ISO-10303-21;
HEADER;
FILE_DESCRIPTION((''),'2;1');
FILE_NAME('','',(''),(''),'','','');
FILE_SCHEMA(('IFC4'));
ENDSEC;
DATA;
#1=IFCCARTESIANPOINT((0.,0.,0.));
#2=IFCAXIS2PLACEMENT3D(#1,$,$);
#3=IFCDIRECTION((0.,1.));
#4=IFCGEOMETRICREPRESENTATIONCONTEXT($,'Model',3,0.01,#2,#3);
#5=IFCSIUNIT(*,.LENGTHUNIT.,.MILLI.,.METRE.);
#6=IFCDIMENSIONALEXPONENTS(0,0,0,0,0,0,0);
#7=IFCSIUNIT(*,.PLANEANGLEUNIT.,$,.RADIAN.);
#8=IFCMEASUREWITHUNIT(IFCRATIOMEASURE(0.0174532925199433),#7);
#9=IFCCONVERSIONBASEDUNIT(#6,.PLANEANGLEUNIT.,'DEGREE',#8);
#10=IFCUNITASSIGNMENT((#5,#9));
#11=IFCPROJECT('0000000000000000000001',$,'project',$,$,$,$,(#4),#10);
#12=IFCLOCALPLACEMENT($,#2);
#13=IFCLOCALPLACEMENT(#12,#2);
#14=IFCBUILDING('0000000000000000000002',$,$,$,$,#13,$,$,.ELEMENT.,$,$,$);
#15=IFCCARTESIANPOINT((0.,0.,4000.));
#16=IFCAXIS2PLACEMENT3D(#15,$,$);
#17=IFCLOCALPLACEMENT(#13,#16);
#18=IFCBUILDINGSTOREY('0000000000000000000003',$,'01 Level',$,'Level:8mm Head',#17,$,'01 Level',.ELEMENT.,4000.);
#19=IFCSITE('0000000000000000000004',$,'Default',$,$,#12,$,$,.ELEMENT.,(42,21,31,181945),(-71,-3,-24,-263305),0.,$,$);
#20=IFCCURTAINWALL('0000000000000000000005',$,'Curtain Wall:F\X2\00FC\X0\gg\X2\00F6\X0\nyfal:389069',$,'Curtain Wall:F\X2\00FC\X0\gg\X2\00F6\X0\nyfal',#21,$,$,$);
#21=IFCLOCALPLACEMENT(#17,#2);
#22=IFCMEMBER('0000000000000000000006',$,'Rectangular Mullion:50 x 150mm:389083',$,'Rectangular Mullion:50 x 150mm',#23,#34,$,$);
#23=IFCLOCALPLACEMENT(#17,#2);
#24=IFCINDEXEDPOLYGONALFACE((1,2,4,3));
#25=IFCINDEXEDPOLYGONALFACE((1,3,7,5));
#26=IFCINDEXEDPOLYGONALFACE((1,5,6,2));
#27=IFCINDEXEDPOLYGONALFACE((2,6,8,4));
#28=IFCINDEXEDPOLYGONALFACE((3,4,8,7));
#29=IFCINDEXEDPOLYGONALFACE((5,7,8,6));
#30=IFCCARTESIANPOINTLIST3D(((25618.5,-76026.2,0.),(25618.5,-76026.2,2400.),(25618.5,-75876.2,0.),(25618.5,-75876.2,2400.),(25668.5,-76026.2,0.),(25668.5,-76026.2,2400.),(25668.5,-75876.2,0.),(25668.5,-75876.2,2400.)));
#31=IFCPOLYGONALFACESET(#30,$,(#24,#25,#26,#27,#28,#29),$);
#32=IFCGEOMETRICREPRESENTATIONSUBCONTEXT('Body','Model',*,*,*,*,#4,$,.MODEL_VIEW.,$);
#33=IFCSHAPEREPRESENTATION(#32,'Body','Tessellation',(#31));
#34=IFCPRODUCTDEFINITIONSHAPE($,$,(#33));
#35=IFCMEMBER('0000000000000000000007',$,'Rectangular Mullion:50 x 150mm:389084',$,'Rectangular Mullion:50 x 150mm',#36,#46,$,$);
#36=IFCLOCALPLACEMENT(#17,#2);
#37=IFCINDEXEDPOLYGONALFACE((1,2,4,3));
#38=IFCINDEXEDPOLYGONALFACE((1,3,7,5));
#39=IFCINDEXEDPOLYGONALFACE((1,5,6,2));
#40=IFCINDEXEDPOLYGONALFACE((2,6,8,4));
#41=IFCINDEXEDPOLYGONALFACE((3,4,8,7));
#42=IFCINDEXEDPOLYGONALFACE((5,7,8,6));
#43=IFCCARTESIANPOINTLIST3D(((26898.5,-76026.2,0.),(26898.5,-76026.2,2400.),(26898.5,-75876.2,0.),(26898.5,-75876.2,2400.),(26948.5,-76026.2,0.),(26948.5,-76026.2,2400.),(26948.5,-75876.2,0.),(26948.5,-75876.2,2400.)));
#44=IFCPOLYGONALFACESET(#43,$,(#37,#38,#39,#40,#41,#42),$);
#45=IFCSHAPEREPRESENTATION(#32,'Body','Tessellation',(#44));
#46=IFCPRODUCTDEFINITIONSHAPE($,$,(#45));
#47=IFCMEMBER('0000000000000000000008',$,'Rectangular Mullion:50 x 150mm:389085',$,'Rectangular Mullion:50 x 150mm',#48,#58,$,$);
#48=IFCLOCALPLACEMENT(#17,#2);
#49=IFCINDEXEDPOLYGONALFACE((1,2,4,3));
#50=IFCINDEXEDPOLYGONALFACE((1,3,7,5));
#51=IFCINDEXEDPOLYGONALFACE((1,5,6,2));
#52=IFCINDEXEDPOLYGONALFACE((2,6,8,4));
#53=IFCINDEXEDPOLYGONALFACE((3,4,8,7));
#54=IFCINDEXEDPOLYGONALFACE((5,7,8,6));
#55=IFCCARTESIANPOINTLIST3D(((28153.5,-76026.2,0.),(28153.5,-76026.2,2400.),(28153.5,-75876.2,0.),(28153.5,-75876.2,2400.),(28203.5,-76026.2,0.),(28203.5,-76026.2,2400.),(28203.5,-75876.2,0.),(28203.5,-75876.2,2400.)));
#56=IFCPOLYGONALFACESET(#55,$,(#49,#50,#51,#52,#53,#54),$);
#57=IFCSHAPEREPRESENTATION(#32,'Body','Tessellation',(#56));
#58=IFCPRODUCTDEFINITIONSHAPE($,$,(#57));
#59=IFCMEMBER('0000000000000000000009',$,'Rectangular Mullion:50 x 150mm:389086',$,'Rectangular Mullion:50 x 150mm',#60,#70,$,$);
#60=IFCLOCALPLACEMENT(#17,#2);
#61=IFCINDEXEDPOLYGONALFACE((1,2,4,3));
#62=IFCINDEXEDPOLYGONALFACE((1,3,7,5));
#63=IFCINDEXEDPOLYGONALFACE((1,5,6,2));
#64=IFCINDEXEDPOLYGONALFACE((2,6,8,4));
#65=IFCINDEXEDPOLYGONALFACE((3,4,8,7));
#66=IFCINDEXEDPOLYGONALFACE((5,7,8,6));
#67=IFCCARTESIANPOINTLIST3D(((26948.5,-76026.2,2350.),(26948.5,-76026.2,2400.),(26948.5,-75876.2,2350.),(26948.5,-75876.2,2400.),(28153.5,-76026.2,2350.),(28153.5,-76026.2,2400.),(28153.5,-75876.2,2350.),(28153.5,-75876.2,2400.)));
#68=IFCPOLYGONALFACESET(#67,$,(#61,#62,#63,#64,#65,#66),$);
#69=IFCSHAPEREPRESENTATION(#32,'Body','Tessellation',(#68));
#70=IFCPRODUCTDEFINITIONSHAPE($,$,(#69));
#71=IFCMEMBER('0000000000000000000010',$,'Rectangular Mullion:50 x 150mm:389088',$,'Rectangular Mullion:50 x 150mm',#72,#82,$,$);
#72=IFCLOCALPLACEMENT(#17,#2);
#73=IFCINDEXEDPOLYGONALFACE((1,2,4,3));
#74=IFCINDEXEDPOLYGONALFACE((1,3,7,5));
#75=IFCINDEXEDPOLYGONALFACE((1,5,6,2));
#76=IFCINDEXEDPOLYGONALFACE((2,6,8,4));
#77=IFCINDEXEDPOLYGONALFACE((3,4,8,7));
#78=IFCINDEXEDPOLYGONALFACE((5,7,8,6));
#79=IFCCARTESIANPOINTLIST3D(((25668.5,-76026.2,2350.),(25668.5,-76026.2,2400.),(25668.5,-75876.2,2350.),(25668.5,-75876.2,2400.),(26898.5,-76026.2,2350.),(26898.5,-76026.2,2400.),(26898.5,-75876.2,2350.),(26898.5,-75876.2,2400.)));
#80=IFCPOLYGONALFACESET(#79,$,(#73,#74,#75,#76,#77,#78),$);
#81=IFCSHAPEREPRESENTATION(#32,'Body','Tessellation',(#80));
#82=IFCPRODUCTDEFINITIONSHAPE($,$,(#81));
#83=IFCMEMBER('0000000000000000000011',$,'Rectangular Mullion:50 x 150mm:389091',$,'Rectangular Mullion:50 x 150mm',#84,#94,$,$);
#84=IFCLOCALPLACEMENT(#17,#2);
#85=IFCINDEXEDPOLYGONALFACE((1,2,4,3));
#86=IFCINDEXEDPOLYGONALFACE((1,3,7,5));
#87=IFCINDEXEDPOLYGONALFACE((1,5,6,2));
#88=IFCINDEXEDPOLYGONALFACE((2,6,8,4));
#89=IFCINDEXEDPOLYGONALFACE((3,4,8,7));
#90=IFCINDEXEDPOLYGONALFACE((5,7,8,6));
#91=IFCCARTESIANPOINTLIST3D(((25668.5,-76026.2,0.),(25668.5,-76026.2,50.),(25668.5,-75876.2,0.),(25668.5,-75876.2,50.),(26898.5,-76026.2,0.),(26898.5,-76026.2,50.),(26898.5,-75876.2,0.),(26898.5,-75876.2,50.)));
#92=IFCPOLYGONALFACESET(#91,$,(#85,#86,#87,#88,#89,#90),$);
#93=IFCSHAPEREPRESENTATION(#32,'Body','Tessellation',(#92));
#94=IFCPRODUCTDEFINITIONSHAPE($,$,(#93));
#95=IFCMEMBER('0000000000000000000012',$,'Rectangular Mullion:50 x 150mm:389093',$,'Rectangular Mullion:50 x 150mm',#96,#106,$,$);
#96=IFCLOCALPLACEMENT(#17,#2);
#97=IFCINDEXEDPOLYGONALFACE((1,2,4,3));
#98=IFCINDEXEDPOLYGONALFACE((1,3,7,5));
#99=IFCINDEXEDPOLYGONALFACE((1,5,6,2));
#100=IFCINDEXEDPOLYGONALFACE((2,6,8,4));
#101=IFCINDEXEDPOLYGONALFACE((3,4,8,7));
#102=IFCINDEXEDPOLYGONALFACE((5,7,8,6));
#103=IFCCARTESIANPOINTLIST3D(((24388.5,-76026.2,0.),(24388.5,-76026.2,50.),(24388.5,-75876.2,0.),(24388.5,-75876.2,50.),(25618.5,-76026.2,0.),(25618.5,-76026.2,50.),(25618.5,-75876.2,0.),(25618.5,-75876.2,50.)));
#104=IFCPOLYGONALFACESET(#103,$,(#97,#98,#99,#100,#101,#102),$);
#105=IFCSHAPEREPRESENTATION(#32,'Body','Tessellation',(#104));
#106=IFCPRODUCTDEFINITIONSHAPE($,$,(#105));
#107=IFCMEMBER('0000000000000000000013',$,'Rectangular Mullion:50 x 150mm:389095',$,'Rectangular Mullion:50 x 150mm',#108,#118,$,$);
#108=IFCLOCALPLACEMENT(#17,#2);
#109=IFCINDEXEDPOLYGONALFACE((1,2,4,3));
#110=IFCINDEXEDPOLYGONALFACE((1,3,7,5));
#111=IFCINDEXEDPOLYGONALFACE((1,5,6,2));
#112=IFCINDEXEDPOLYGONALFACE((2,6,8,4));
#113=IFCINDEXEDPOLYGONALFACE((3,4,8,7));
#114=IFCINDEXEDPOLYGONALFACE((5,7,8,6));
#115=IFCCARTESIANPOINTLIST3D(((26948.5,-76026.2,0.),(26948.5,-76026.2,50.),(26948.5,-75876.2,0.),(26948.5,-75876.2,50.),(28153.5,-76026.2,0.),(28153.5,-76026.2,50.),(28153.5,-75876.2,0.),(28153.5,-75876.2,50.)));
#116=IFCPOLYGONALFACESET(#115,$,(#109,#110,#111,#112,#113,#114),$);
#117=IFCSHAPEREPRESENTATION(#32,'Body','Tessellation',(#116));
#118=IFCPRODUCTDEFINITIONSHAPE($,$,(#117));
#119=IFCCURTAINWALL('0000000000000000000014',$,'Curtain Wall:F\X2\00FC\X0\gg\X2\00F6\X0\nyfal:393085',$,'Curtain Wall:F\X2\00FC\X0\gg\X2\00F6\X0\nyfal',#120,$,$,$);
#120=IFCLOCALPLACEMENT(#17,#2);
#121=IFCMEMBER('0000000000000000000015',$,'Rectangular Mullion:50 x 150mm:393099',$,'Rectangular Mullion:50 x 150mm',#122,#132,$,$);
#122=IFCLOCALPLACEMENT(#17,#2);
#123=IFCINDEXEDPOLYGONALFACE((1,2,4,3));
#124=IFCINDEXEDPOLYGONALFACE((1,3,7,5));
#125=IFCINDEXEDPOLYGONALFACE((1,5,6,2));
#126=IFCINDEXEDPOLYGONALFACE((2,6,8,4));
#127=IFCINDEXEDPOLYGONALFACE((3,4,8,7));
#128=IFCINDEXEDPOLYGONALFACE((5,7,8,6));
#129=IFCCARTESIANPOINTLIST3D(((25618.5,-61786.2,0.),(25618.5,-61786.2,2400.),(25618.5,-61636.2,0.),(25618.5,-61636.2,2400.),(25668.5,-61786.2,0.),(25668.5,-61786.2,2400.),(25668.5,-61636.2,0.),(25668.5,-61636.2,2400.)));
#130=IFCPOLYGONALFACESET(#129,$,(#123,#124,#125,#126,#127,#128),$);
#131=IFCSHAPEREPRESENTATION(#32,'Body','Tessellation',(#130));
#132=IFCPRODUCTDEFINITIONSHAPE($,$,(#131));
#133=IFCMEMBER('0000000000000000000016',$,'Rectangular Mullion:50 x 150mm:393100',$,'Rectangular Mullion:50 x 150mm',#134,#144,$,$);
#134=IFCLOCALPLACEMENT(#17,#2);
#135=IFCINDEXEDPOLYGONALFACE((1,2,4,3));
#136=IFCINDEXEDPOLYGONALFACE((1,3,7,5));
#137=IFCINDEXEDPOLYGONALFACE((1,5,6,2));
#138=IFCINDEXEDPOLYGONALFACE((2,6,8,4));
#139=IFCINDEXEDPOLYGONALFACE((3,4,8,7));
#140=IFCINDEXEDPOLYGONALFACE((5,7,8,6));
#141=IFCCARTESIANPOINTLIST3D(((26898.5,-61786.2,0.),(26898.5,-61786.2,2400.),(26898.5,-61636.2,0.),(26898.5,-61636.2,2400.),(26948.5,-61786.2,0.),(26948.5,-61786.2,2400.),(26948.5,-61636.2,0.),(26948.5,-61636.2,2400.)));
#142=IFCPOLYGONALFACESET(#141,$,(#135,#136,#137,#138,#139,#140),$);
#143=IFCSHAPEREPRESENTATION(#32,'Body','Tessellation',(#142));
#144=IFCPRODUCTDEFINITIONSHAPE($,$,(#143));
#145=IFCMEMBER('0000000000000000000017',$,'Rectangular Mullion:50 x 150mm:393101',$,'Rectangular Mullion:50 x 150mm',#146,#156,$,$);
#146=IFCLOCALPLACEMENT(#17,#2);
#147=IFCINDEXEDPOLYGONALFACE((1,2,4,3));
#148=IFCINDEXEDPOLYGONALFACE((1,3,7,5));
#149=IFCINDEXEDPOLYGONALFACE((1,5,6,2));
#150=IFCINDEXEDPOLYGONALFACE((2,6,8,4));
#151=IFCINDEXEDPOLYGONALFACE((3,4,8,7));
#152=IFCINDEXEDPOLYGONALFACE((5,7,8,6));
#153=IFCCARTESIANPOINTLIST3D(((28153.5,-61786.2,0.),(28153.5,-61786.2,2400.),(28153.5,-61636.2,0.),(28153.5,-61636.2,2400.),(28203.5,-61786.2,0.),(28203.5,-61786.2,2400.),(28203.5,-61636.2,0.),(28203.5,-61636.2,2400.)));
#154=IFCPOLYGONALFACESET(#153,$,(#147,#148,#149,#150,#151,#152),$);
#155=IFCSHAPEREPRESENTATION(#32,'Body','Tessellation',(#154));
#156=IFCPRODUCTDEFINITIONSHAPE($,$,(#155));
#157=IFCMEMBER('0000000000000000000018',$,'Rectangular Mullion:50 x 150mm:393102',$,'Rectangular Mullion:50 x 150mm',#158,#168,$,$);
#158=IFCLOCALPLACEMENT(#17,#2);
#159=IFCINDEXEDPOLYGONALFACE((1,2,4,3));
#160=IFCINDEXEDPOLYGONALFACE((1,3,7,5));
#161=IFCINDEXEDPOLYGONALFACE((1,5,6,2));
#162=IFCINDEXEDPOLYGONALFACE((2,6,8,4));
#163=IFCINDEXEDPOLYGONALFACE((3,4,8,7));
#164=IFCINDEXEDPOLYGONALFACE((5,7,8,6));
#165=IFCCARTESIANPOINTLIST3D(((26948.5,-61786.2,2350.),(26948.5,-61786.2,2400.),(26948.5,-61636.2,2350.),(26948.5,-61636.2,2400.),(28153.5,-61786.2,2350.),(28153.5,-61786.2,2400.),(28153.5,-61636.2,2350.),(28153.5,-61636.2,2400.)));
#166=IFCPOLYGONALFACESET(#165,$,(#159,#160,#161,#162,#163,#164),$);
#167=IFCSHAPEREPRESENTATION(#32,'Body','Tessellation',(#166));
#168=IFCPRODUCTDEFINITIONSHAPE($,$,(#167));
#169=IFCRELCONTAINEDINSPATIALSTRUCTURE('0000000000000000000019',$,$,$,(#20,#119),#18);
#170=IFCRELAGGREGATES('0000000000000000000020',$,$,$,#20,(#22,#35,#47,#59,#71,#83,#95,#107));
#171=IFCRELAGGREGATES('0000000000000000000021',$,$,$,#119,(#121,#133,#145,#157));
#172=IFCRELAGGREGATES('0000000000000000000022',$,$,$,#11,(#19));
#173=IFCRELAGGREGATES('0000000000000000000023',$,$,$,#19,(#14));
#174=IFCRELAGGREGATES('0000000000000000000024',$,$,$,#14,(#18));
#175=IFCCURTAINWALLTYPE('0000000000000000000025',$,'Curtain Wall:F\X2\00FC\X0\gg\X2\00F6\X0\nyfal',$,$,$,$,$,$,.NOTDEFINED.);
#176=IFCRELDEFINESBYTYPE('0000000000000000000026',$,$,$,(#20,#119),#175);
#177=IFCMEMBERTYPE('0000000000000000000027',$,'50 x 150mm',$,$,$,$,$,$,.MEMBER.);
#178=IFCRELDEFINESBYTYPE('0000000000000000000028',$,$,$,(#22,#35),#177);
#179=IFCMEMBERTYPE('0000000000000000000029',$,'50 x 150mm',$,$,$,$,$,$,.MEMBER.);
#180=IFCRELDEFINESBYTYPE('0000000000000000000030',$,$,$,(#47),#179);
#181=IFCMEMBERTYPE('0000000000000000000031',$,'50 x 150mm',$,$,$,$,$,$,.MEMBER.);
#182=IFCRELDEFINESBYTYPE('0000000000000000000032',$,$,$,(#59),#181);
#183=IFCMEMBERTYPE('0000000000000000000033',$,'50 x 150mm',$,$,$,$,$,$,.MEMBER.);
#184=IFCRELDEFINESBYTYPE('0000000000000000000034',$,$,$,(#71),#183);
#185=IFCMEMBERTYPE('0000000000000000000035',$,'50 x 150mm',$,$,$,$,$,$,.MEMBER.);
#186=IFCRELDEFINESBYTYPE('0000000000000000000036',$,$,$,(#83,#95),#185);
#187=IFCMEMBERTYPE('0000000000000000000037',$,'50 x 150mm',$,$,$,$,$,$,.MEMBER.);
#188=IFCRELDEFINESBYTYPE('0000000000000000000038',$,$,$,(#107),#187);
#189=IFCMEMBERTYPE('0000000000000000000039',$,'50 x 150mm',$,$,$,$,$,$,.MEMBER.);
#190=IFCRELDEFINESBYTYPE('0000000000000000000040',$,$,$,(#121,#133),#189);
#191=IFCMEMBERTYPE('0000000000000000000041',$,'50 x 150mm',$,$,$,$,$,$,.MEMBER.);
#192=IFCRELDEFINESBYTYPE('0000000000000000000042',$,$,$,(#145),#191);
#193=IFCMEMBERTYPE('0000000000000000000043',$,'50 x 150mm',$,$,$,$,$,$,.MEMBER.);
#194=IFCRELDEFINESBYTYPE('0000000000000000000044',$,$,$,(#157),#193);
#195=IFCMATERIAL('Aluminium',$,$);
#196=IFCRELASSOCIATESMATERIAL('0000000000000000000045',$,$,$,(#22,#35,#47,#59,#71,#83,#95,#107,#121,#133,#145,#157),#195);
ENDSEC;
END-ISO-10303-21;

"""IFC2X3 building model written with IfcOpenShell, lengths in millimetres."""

from ifc_helpers import new_model, entity, si_unit, converted_unit, direction, frame, origin, origin_2d_with_axis, place, context, subcontext, project, spatial, rectangle, extrude, source, transform, mapped, material, type_object, type_shapes, element, aggregate, save


model = new_model("IFC2X3")

# Units and contexts
model_context = context("Model", 3, precision=0.01, world=origin(), true_north=direction((0.0, 1.0)))
body_context = subcontext(model_context, "Body", "Model", "MODEL_VIEW")
ifc_project = project(units=[si_unit("LENGTHUNIT", "METRE", prefix="MILLI"), converted_unit("PLANEANGLEUNIT", "DEGREE", entity("IfcRatioMeasure", 0.0174532925199433), si_unit("PLANEANGLEUNIT", "RADIAN"), dimensions=[0, 0, 0, 0, 0, 0, 0])], contexts=[model_context])

# Site, building, storey
site_placement = place(None, origin())
site = spatial("IfcSite", under=ifc_project, at=site_placement, Name="Default", CompositionType="ELEMENT", RefLatitude=(42, 21, 31, 181945), RefLongitude=(-71, -3, -24, -263305), RefElevation=0.0)
building_placement = place(site_placement, origin())
building = spatial("IfcBuilding", under=site, at=building_placement, CompositionType="ELEMENT")
storey_placement = place(building_placement, frame((0.0, 0.0, 4000.0)))
storey = spatial("IfcBuildingStorey", under=building, at=storey_placement, Name="01 Level", ObjectType="Level:8mm Head", LongName="01 Level", CompositionType="ELEMENT", Elevation=4000.0)

# Curtain walls, members
curtain_wall_type = type_object("IfcCurtainWallType", Name="Curtain Wall:Függönyfal", PredefinedType="NOTDEFINED")
curtain_wall_1_placement = place(storey_placement, frame((0.0, 0.0, -4000.0)))
curtain_wall_1 = element("IfcCurtainWall", 1, at=curtain_wall_1_placement, inside=storey, type_object=curtain_wall_type, Name="Curtain Wall:Függönyfal:389069", ObjectType="Curtain Wall:Függönyfal")
ifc_material_1 = material(Name="Aluminium")
member_type_1 = type_object("IfcMemberType", Name="50 x 150mm", PredefinedType="MEMBER")
shared_shape_1 = source(origin(), body_context, "Body", "SweptSolid", [
    extrude(rectangle(XDim=150.0, YDim=50.0, at=origin_2d_with_axis()), frame((0.0, 0.0, -2400.0), z_axis=(0.0, 0.0, 1.0), x_axis=(0.0, -1.0, 0.0)), (0.0, 0.0, 1.0), 2400.0),
])
type_shapes(member_type_1, [shared_shape_1])
member_1_placement = place(storey_placement, frame((25643.5, -75951.2, 0.0), z_axis=(0.0, 0.0, -1.0), x_axis=(-1.0, 0.0, 0.0)))
member_1 = element("IfcMember", 2, at=member_1_placement, type_object=member_type_1, material=ifc_material_1, Name="Rectangular Mullion:50 x 150mm:389083", ObjectType="Rectangular Mullion:50 x 150mm", context=body_context, shape_type="MappedRepresentation", body=[
    mapped(shared_shape_1, transform((0.0, 0.0, 0.0), scale=1.0)),
])
member_2_placement = place(storey_placement, frame((26923.5, -75951.2, 0.0), z_axis=(0.0, 0.0, -1.0), x_axis=(-1.0, 0.0, 0.0)))
member_2 = element("IfcMember", 3, at=member_2_placement, type_object=member_type_1, material=ifc_material_1, Name="Rectangular Mullion:50 x 150mm:389084", ObjectType="Rectangular Mullion:50 x 150mm", context=body_context, shape_type="MappedRepresentation", body=[
    mapped(shared_shape_1, transform((0.0, 0.0, 0.0), scale=1.0)),
])
member_type_2 = type_object("IfcMemberType", Name="50 x 150mm", PredefinedType="MEMBER")
shared_shape_2 = source(origin(), body_context, "Body", "SweptSolid", [
    extrude(rectangle(XDim=150.0, YDim=50.0, at=origin_2d_with_axis()), frame((-25.0, 0.0, -2400.0), z_axis=(0.0, 0.0, 1.0), x_axis=(0.0, -1.0, 0.0)), (0.0, 0.0, 1.0), 2400.0),
])
type_shapes(member_type_2, [shared_shape_2])
member_3_placement = place(storey_placement, frame((28203.5, -75951.2, 2400.0)))
member_3 = element("IfcMember", 4, at=member_3_placement, type_object=member_type_2, material=ifc_material_1, Name="Rectangular Mullion:50 x 150mm:389085", ObjectType="Rectangular Mullion:50 x 150mm", context=body_context, shape_type="MappedRepresentation", body=[
    mapped(shared_shape_2, transform((0.0, 0.0, 0.0), scale=1.0)),
])
member_type_3 = type_object("IfcMemberType", Name="50 x 150mm", PredefinedType="MEMBER")
shared_shape_3 = source(origin(), body_context, "Body", "SweptSolid", [
    extrude(rectangle(XDim=150.0, YDim=50.0, at=origin_2d_with_axis()), frame((-25.0, 0.0, -1205.0), z_axis=(0.0, 0.0, 1.0), x_axis=(0.0, -1.0, 0.0)), (0.0, 0.0, 1.0), 1205.0),
])
type_shapes(member_type_3, [shared_shape_3])
member_4_placement = place(storey_placement, frame((26948.5, -75951.2, 2400.0), z_axis=(-1.0, 0.0, 0.0), x_axis=(0.0, 0.0, 1.0)))
member_4 = element("IfcMember", 5, at=member_4_placement, type_object=member_type_3, material=ifc_material_1, Name="Rectangular Mullion:50 x 150mm:389086", ObjectType="Rectangular Mullion:50 x 150mm", context=body_context, shape_type="MappedRepresentation", body=[
    mapped(shared_shape_3, transform((0.0, 0.0, 0.0), scale=1.0)),
])
member_type_4 = type_object("IfcMemberType", Name="50 x 150mm", PredefinedType="MEMBER")
shared_shape_4 = source(origin(), body_context, "Body", "SweptSolid", [
    extrude(rectangle(XDim=150.0, YDim=50.0, at=origin_2d_with_axis()), frame((-25.0, 0.0, -1230.0), z_axis=(0.0, 0.0, 1.0), x_axis=(0.0, -1.0, 0.0)), (0.0, 0.0, 1.0), 1230.0),
])
type_shapes(member_type_4, [shared_shape_4])
member_5_placement = place(storey_placement, frame((25668.5, -75951.2, 2400.0), z_axis=(-1.0, 0.0, 0.0), x_axis=(0.0, 0.0, 1.0)))
member_5 = element("IfcMember", 6, at=member_5_placement, type_object=member_type_4, material=ifc_material_1, Name="Rectangular Mullion:50 x 150mm:389088", ObjectType="Rectangular Mullion:50 x 150mm", context=body_context, shape_type="MappedRepresentation", body=[
    mapped(shared_shape_4, transform((0.0, 0.0, 0.0), scale=1.0)),
])
member_type_5 = type_object("IfcMemberType", Name="50 x 150mm", PredefinedType="MEMBER")
shared_shape_5 = source(origin(), body_context, "Body", "SweptSolid", [
    extrude(rectangle(XDim=150.0, YDim=50.0, at=origin_2d_with_axis()), frame((-25.0, 0.0, -1230.0), z_axis=(0.0, 0.0, 1.0), x_axis=(0.0, -1.0, 0.0)), (0.0, 0.0, 1.0), 1230.0),
])
type_shapes(member_type_5, [shared_shape_5])
member_6_placement = place(storey_placement, frame((26898.5, -75951.2, 0.0), z_axis=(1.0, 0.0, 0.0), x_axis=(0.0, 0.0, -1.0)))
member_6 = element("IfcMember", 7, at=member_6_placement, type_object=member_type_5, material=ifc_material_1, Name="Rectangular Mullion:50 x 150mm:389091", ObjectType="Rectangular Mullion:50 x 150mm", context=body_context, shape_type="MappedRepresentation", body=[
    mapped(shared_shape_5, transform((0.0, 0.0, 0.0), scale=1.0)),
])
member_7_placement = place(storey_placement, frame((25618.5, -75951.2, 0.0), z_axis=(1.0, 0.0, 0.0), x_axis=(0.0, 0.0, -1.0)))
member_7 = element("IfcMember", 8, at=member_7_placement, type_object=member_type_5, material=ifc_material_1, Name="Rectangular Mullion:50 x 150mm:389093", ObjectType="Rectangular Mullion:50 x 150mm", context=body_context, shape_type="MappedRepresentation", body=[
    mapped(shared_shape_5, transform((0.0, 0.0, 0.0), scale=1.0)),
])
member_type_6 = type_object("IfcMemberType", Name="50 x 150mm", PredefinedType="MEMBER")
shared_shape_6 = source(origin(), body_context, "Body", "SweptSolid", [
    extrude(rectangle(XDim=150.0, YDim=50.0, at=origin_2d_with_axis()), frame((-25.0, 0.0, -1205.0), z_axis=(0.0, 0.0, 1.0), x_axis=(0.0, -1.0, 0.0)), (0.0, 0.0, 1.0), 1205.0),
])
type_shapes(member_type_6, [shared_shape_6])
member_8_placement = place(storey_placement, frame((28153.5, -75951.2, 0.0), z_axis=(1.0, 0.0, 0.0), x_axis=(0.0, 0.0, -1.0)))
member_8 = element("IfcMember", 9, at=member_8_placement, type_object=member_type_6, material=ifc_material_1, Name="Rectangular Mullion:50 x 150mm:389095", ObjectType="Rectangular Mullion:50 x 150mm", context=body_context, shape_type="MappedRepresentation", body=[
    mapped(shared_shape_6, transform((0.0, 0.0, 0.0), scale=1.0)),
])
curtain_wall_2_placement = place(storey_placement, frame((0.0, 0.0, -4000.0)))
curtain_wall_2 = element("IfcCurtainWall", 10, at=curtain_wall_2_placement, inside=storey, type_object=curtain_wall_type, Name="Curtain Wall:Függönyfal:393085", ObjectType="Curtain Wall:Függönyfal")
member_type_7 = type_object("IfcMemberType", Name="50 x 150mm", PredefinedType="MEMBER")
shared_shape_7 = source(origin(), body_context, "Body", "SweptSolid", [
    extrude(rectangle(XDim=150.0, YDim=50.0, at=origin_2d_with_axis()), frame((0.0, 0.0, -2400.0), z_axis=(0.0, 0.0, 1.0), x_axis=(0.0, -1.0, 0.0)), (0.0, 0.0, 1.0), 2400.0),
])
type_shapes(member_type_7, [shared_shape_7])
member_9_placement = place(storey_placement, frame((25643.5, -61711.2, 0.0), z_axis=(0.0, 0.0, -1.0), x_axis=(-1.0, 0.0, 0.0)))
member_9 = element("IfcMember", 11, at=member_9_placement, type_object=member_type_7, material=ifc_material_1, Name="Rectangular Mullion:50 x 150mm:393099", ObjectType="Rectangular Mullion:50 x 150mm", context=body_context, shape_type="MappedRepresentation", body=[
    mapped(shared_shape_7, transform((0.0, 0.0, 0.0), scale=1.0)),
])
member_10_placement = place(storey_placement, frame((26923.5, -61711.2, 0.0), z_axis=(0.0, 0.0, -1.0), x_axis=(-1.0, 0.0, 0.0)))
member_10 = element("IfcMember", 12, at=member_10_placement, type_object=member_type_7, material=ifc_material_1, Name="Rectangular Mullion:50 x 150mm:393100", ObjectType="Rectangular Mullion:50 x 150mm", context=body_context, shape_type="MappedRepresentation", body=[
    mapped(shared_shape_7, transform((0.0, 0.0, 0.0), scale=1.0)),
])
member_type_8 = type_object("IfcMemberType", Name="50 x 150mm", PredefinedType="MEMBER")
shared_shape_8 = source(origin(), body_context, "Body", "SweptSolid", [
    extrude(rectangle(XDim=150.0, YDim=50.0, at=origin_2d_with_axis()), frame((-25.0, 0.0, -2400.0), z_axis=(0.0, 0.0, 1.0), x_axis=(0.0, -1.0, 0.0)), (0.0, 0.0, 1.0), 2400.0),
])
type_shapes(member_type_8, [shared_shape_8])
member_11_placement = place(storey_placement, frame((28203.5, -61711.2, 2400.0)))
member_11 = element("IfcMember", 13, at=member_11_placement, type_object=member_type_8, material=ifc_material_1, Name="Rectangular Mullion:50 x 150mm:393101", ObjectType="Rectangular Mullion:50 x 150mm", context=body_context, shape_type="MappedRepresentation", body=[
    mapped(shared_shape_8, transform((0.0, 0.0, 0.0), scale=1.0)),
])
member_type_9 = type_object("IfcMemberType", Name="50 x 150mm", PredefinedType="MEMBER")
shared_shape_9 = source(origin(), body_context, "Body", "SweptSolid", [
    extrude(rectangle(XDim=150.0, YDim=50.0, at=origin_2d_with_axis()), frame((-25.0, 0.0, -1205.0), z_axis=(0.0, 0.0, 1.0), x_axis=(0.0, -1.0, 0.0)), (0.0, 0.0, 1.0), 1205.0),
])
type_shapes(member_type_9, [shared_shape_9])
member_12_placement = place(storey_placement, frame((26948.5, -61711.2, 2400.0), z_axis=(-1.0, 0.0, 0.0), x_axis=(0.0, 0.0, 1.0)))
member_12 = element("IfcMember", 14, at=member_12_placement, type_object=member_type_9, material=ifc_material_1, Name="Rectangular Mullion:50 x 150mm:393102", ObjectType="Rectangular Mullion:50 x 150mm", context=body_context, shape_type="MappedRepresentation", body=[
    mapped(shared_shape_9, transform((0.0, 0.0, 0.0), scale=1.0)),
])

aggregate(curtain_wall_1, [member_1, member_2, member_3, member_4, member_5, member_6, member_7, member_8])
aggregate(curtain_wall_2, [member_9, member_10, member_11, member_12])

save(model, "model.ifc")
